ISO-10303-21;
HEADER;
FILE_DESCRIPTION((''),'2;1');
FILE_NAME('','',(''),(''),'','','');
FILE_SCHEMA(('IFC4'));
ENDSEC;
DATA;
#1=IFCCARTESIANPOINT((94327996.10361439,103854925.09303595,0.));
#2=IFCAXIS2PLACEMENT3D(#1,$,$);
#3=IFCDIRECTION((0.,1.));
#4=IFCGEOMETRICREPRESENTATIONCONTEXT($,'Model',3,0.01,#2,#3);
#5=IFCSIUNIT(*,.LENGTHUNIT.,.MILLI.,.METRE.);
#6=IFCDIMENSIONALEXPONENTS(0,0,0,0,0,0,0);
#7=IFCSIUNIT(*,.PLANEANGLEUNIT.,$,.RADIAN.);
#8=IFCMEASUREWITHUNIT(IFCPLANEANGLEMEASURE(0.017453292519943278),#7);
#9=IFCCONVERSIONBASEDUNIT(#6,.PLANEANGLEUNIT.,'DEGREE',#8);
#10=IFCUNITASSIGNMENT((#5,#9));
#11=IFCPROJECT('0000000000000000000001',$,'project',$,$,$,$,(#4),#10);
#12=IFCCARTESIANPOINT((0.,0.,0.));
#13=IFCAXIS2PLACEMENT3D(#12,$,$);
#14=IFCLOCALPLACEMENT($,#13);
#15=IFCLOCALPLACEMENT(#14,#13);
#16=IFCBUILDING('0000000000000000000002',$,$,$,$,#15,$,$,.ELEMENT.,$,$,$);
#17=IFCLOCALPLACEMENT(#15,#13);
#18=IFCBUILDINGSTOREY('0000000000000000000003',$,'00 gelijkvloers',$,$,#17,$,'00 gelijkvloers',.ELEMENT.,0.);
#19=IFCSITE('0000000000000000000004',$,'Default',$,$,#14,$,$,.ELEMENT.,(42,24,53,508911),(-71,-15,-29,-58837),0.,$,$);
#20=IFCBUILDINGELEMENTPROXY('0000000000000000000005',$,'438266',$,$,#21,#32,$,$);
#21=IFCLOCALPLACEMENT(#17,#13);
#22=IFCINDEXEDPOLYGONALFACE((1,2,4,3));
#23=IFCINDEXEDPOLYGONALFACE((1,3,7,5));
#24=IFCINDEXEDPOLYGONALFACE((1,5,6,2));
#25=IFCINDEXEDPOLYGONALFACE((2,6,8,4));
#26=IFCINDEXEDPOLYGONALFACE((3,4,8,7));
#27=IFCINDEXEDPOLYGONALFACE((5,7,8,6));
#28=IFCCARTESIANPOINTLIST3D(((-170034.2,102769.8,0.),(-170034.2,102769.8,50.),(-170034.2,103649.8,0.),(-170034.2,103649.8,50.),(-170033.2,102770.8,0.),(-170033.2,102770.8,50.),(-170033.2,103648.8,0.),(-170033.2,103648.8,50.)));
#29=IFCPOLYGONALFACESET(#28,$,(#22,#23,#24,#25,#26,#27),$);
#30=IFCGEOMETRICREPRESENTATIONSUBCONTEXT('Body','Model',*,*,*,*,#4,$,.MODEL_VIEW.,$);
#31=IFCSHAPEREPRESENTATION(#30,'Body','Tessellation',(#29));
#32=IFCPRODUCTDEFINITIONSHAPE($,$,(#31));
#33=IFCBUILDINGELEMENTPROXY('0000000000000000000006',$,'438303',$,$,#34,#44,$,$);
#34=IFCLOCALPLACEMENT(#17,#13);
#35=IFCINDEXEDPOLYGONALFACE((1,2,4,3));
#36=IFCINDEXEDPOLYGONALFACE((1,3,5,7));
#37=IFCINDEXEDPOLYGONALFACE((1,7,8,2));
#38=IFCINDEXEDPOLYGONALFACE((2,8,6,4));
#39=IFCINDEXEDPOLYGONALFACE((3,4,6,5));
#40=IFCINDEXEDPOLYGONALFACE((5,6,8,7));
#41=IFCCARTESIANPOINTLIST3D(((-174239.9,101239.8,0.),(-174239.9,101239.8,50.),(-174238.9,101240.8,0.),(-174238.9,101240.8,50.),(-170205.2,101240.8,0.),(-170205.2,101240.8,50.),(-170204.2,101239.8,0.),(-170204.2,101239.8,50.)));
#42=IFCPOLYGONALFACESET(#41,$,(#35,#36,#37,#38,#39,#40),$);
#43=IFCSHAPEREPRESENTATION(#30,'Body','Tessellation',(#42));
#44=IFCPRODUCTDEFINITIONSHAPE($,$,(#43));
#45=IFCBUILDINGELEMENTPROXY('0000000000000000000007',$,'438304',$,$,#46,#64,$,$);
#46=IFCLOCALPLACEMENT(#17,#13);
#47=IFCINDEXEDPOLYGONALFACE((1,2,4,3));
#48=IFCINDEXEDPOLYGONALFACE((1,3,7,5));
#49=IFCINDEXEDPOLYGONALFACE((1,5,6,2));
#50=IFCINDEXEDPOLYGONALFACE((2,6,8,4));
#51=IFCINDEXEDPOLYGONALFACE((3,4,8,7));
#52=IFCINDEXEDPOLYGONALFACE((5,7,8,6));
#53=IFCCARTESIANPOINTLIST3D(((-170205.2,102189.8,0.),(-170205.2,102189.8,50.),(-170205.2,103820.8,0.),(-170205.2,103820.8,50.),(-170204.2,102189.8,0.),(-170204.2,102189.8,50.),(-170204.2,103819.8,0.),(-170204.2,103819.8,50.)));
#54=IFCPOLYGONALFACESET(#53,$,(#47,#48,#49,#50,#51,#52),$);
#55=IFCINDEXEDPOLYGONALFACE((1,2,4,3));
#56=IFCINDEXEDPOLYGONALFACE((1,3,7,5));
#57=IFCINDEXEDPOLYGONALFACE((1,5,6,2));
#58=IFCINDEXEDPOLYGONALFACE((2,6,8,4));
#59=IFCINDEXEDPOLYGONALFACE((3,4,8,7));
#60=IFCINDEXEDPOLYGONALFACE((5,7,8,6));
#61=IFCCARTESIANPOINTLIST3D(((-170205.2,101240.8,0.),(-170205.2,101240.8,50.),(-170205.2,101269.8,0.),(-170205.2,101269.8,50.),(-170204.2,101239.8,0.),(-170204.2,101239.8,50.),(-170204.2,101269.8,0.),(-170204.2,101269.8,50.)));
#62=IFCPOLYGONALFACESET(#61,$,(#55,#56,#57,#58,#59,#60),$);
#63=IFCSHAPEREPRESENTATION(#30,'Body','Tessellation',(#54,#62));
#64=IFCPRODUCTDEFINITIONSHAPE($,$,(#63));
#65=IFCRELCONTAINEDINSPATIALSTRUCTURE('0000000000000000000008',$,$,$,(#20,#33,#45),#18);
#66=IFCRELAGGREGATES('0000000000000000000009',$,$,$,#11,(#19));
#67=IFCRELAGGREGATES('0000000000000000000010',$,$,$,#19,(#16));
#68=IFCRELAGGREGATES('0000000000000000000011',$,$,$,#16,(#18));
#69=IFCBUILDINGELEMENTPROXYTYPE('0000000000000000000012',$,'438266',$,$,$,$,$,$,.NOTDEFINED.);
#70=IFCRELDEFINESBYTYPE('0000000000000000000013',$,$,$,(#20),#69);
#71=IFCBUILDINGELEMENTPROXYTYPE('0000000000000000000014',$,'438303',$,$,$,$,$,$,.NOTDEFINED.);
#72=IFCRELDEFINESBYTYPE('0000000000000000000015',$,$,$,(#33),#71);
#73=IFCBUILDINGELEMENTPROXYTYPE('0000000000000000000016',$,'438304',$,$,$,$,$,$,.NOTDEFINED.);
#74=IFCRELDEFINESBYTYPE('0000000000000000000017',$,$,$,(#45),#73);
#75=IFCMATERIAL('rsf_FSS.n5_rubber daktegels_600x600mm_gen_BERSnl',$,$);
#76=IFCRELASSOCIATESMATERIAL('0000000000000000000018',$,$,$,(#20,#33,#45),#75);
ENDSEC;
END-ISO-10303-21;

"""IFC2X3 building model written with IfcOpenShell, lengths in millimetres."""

from ifc_helpers import new_model, entity, si_unit, converted_unit, direction, frame, origin, place, context, subcontext, project, spatial, polyline, outline, extrude, material, type_object, element, save


model = new_model("IFC2X3")

# Units and contexts
model_context = context("Model", 3, precision=0.01, world=frame((94327996.10361439, 103854925.09303595, 0.0)), true_north=direction((0.0, 1.0)))
body_context = subcontext(model_context, "Body", "Model", "MODEL_VIEW")
ifc_project = project(units=[si_unit("LENGTHUNIT", "METRE", prefix="MILLI"), converted_unit("PLANEANGLEUNIT", "DEGREE", entity("IfcPlaneAngleMeasure", 0.017453292519943278), si_unit("PLANEANGLEUNIT", "RADIAN"), dimensions=[0, 0, 0, 0, 0, 0, 0])], contexts=[model_context])

# Site, building, storey
site_placement = place(None, origin())
site = spatial("IfcSite", under=ifc_project, at=site_placement, Name="Default", CompositionType="ELEMENT", RefLatitude=(42, 24, 53, 508911), RefLongitude=(-71, -15, -29, -58837), RefElevation=0.0)
building_placement = place(site_placement, origin())
building = spatial("IfcBuilding", under=site, at=building_placement, CompositionType="ELEMENT")
storey_placement = place(building_placement, origin())
storey = spatial("IfcBuildingStorey", under=building, at=storey_placement, Name="00 gelijkvloers", LongName="00 gelijkvloers", CompositionType="ELEMENT", Elevation=0.0)

# Building element proxies
ifc_material = material(Name="rsf_FSS.n5_rubber daktegels_600x600mm_gen_BERSnl")
building_element_proxy_type_1 = type_object("IfcBuildingElementProxyType", Name="438266", PredefinedType="NOTDEFINED")
proxy_1_placement = place(storey_placement, origin())
element("IfcBuildingElementProxy", 1, at=proxy_1_placement, inside=storey, type_object=building_element_proxy_type_1, material=ifc_material, Name="438266", context=body_context, shape_type="SweptSolid", body=[
    extrude(outline(polyline([(-439.0, -0.5), (439.0, -0.5), (440.0, 0.5), (-440.0, 0.5), (-439.0, -0.5)])), frame((-170033.7, 103209.8, 0.0), z_axis=(0.0, 0.0, 1.0), x_axis=(0.0, 1.0, 0.0)), (0.0, 0.0, 1.0), 50.0),
])
building_element_proxy_type_2 = type_object("IfcBuildingElementProxyType", Name="438303", PredefinedType="NOTDEFINED")
proxy_2_placement = place(storey_placement, origin())
element("IfcBuildingElementProxy", 2, at=proxy_2_placement, inside=storey, type_object=building_element_proxy_type_2, material=ifc_material, Name="438303", context=body_context, shape_type="SweptSolid", body=[
    extrude(outline(polyline([(-2016.9, -0.5), (2016.9, -0.5), (2017.9, 0.5), (-2017.9, 0.5), (-2016.9, -0.5)])), frame((-172222.0, 101240.3, 0.0), z_axis=(0.0, 0.0, 1.0), x_axis=(-1.0, 0.0, 0.0)), (0.0, 0.0, 1.0), 50.0),
])
building_element_proxy_type_3 = type_object("IfcBuildingElementProxyType", Name="438304", PredefinedType="NOTDEFINED")
proxy_3_placement = place(storey_placement, origin())
element("IfcBuildingElementProxy", 3, at=proxy_3_placement, inside=storey, type_object=building_element_proxy_type_3, material=ifc_material, Name="438304", context=body_context, shape_type="SweptSolid", body=[
    extrude(outline(polyline([(-815.8, -0.5), (815.3, -0.5), (815.3, 0.5), (-814.8, 0.5), (-815.8, -0.5)])), frame((-170204.7, 103005.0, 0.0), z_axis=(0.0, 0.0, 1.0), x_axis=(0.0, -1.0, 0.0)), (0.0, 0.0, 1.0), 50.0),
    extrude(outline(polyline([(-14.7, -0.5), (14.2, -0.5), (15.2, 0.5), (-14.7, 0.5), (-14.7, -0.5)])), frame((-170204.7, 101255.0, 0.0), z_axis=(0.0, 0.0, 1.0), x_axis=(0.0, -1.0, 0.0)), (0.0, 0.0, 1.0), 50.0),
])

save(model, "model.ifc")
